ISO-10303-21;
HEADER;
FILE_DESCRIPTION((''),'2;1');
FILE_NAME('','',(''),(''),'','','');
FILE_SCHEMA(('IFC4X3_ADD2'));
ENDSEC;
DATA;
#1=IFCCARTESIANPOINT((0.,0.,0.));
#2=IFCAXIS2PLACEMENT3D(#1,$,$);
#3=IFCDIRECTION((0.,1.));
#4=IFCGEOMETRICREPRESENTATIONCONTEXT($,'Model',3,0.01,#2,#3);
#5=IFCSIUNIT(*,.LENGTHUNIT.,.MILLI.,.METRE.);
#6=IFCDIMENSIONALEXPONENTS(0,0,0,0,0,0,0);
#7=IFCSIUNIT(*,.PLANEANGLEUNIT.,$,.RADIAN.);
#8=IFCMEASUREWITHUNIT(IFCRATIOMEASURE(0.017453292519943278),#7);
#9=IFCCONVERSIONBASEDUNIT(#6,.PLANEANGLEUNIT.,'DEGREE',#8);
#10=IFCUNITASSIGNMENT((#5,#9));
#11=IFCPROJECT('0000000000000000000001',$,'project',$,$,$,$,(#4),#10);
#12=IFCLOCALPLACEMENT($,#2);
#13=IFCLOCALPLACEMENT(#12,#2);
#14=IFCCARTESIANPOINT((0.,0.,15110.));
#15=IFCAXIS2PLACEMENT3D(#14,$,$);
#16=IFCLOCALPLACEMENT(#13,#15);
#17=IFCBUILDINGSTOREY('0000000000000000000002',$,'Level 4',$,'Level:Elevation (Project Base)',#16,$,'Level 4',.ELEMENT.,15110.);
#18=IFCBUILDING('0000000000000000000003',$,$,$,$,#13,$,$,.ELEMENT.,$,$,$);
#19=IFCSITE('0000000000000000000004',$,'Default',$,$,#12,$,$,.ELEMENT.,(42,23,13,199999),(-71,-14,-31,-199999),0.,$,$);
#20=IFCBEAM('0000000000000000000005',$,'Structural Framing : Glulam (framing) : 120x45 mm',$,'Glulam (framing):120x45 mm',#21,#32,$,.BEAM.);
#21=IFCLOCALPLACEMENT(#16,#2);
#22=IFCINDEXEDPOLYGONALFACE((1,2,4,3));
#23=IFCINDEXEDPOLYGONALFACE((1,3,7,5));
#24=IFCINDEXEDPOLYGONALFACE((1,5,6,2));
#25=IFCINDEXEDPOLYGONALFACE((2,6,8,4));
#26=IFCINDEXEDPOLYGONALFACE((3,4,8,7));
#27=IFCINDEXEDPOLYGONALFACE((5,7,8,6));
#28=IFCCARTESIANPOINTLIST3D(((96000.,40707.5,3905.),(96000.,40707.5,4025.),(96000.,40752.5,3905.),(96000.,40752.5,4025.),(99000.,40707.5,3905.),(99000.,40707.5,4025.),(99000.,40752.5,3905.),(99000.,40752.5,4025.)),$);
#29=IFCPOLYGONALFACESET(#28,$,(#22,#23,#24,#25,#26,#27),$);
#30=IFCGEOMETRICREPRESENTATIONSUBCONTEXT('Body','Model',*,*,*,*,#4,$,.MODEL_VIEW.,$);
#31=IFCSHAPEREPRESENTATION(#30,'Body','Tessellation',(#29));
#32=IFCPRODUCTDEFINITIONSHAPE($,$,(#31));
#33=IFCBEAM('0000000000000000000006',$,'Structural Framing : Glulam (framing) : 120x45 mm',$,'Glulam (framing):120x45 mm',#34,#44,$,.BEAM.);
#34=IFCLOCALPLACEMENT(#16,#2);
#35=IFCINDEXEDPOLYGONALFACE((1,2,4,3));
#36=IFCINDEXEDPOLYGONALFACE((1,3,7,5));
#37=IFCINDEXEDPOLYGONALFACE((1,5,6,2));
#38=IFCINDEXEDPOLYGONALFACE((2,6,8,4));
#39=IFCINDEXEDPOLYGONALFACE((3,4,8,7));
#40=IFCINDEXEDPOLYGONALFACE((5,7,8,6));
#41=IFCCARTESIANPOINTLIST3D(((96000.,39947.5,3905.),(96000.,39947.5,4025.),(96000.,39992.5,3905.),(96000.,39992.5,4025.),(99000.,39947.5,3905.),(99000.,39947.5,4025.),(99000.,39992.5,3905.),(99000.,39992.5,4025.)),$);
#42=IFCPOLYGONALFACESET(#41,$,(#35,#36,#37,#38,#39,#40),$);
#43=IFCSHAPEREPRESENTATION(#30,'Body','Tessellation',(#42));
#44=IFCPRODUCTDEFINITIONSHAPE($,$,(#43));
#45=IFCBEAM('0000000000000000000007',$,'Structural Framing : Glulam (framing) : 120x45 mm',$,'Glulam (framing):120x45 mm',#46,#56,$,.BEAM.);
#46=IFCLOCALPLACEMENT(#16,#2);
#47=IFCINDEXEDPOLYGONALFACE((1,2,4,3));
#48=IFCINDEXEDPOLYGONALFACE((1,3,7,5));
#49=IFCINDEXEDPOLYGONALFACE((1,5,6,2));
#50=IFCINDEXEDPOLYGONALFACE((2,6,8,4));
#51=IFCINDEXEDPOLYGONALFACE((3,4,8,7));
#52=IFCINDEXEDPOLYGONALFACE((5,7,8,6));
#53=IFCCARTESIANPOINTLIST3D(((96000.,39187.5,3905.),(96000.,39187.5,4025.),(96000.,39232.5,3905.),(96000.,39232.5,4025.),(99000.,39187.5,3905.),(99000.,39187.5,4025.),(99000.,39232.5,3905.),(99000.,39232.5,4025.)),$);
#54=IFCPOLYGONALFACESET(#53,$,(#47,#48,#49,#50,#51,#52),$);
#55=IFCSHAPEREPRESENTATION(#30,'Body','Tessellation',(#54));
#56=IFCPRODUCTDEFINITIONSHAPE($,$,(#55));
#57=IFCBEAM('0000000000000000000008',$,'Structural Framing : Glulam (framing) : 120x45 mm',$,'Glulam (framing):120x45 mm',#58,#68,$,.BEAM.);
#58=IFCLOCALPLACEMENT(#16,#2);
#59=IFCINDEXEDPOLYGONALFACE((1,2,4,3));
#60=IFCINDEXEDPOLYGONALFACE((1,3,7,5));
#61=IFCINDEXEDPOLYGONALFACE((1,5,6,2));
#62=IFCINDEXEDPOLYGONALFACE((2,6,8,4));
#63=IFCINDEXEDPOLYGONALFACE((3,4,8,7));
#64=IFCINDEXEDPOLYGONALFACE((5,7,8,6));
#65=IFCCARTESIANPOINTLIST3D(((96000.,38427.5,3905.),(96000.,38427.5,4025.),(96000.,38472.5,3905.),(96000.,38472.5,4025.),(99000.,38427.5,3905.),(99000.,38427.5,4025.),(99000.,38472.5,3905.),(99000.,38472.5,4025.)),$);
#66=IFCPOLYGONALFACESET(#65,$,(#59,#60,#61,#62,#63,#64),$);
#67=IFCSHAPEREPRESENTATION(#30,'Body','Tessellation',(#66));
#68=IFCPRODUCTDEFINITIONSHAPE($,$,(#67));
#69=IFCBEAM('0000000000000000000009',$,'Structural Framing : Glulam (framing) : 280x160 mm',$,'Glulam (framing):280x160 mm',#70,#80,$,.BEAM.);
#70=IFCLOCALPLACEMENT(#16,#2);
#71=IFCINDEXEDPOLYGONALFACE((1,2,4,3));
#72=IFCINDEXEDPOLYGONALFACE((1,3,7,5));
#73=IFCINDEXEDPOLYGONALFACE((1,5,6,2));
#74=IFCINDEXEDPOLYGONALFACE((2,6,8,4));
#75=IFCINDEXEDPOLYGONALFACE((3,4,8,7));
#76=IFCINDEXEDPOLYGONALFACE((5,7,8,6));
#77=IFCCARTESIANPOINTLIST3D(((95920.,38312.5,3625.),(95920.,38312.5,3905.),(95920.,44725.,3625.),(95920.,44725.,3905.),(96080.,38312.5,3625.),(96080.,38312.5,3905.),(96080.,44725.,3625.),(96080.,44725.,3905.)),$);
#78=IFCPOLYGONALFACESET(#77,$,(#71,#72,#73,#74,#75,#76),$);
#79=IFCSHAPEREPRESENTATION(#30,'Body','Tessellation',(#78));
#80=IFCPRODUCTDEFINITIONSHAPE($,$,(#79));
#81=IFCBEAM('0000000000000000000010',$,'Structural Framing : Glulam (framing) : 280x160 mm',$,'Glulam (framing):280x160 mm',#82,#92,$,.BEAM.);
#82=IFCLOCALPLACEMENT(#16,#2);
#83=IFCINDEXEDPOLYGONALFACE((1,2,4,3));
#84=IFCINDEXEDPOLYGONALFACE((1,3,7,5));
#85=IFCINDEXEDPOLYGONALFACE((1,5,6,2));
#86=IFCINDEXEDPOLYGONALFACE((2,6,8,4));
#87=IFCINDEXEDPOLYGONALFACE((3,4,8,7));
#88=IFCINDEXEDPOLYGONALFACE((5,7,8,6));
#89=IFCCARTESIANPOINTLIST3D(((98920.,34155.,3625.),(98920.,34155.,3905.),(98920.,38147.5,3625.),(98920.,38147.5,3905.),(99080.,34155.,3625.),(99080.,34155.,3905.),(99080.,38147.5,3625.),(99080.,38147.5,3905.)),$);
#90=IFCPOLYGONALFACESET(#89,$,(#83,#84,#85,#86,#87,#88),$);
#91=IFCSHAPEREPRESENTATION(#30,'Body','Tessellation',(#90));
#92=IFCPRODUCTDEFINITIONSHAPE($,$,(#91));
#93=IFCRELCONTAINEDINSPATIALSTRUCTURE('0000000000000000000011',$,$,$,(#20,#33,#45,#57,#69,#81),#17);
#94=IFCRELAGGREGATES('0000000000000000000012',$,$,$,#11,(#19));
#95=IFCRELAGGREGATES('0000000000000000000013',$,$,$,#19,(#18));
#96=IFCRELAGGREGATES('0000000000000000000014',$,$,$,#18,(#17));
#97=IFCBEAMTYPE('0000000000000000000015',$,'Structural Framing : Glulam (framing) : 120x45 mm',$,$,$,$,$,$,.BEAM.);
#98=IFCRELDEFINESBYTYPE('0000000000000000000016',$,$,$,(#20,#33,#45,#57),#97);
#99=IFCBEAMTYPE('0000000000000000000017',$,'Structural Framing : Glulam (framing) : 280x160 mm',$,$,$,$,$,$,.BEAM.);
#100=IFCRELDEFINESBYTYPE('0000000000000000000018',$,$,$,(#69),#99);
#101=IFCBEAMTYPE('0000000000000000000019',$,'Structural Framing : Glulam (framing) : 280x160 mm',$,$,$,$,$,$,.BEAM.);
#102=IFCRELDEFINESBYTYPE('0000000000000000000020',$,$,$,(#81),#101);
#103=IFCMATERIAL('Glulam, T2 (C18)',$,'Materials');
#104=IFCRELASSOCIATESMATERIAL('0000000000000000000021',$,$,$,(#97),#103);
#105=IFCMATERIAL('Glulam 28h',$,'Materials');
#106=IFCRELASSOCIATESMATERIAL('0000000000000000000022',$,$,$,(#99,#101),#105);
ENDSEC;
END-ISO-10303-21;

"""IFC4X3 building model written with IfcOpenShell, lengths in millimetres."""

from ifc_helpers import new_model, entity, si_unit, converted_unit, direction, frame, origin, origin_2d_with_axis, place, context, subcontext, project, spatial, rectangle, extrude, source, transform, mapped, material, material_profile, profile_set, type_object, type_shapes, element, save


model = new_model("IFC4X3")

# Units and contexts
model_context = context("Model", 3, precision=0.01, world=origin(), true_north=direction((0.0, 1.0)))
body_context = subcontext(model_context, "Body", "Model", "MODEL_VIEW")
ifc_project = project(units=[si_unit("LENGTHUNIT", "METRE", prefix="MILLI"), converted_unit("PLANEANGLEUNIT", "DEGREE", entity("IfcRatioMeasure", 0.017453292519943278), si_unit("PLANEANGLEUNIT", "RADIAN"), dimensions=[0, 0, 0, 0, 0, 0, 0])], contexts=[model_context])

# Site, building, storey
site_placement = place(None, origin())
site = spatial("IfcSite", under=ifc_project, at=site_placement, Name="Default", CompositionType="ELEMENT", RefLatitude=(42, 23, 13, 199999), RefLongitude=(-71, -14, -31, -199999), RefElevation=0.0)
building_placement = place(site_placement, origin())
building = spatial("IfcBuilding", under=site, at=building_placement, CompositionType="ELEMENT")
storey_placement = place(building_placement, frame((0.0, 0.0, 15110.0)))
storey = spatial("IfcBuildingStorey", under=building, at=storey_placement, Name="Level 4", ObjectType="Level:Elevation (Project Base)", LongName="Level 4", CompositionType="ELEMENT", Elevation=15110.0)

# Beams
ifc_material_1 = material(Name="Glulam 28h", Category="Materials")
ifc_material_profile_1 = material_profile(ifc_material_1, rectangle(XDim=280.0, YDim=160.0, at=origin_2d_with_axis()), Name="280x160 mm")
ifc_profile_set_1 = profile_set([ifc_material_profile_1], Name="280x160 mm")
ifc_material_2 = material(Name="Glulam, T2 (C18)", Category="Materials")
ifc_material_profile_2 = material_profile(ifc_material_2, rectangle(XDim=120.0, YDim=45.0, at=origin_2d_with_axis()), Name="120x45 mm")
ifc_profile_set_2 = profile_set([ifc_material_profile_2], Name="120x45 mm")
beam_type_1 = type_object("IfcBeamType", Name="Structural Framing : Glulam (framing) : 120x45 mm", PredefinedType="BEAM", material=ifc_profile_set_2)
shared_shape_1 = source(origin(), body_context, "Body", "SweptSolid", [
    extrude(rectangle(XDim=120.0, YDim=45.0, at=origin_2d_with_axis()), frame((500.0, 0.0, 0.0), z_axis=(1.0, 0.0, 0.0), x_axis=(0.0, 0.0, -1.0)), (0.0, 0.0, 1.0), 3000.0),
])
type_shapes(beam_type_1, [shared_shape_1])
for number, where, name in (
    (1, (95500.0, 40730.0, 3965.0), "Structural Framing : Glulam (framing) : 120x45 mm"),
    (2, (95500.0, 39970.0, 3965.0), "Structural Framing : Glulam (framing) : 120x45 mm"),
    (3, (95500.0, 39210.0, 3965.0), "Structural Framing : Glulam (framing) : 120x45 mm"),
    (4, (95500.0, 38450.0, 3965.0), "Structural Framing : Glulam (framing) : 120x45 mm"),
):
    element("IfcBeam", number, at=place(storey_placement, frame(where)), inside=storey, type_object=beam_type_1, Name=name, ObjectType="Glulam (framing):120x45 mm", PredefinedType="BEAM", context=body_context, shape_type="MappedRepresentation", body=[
        mapped(shared_shape_1, transform((0.0, 0.0, 0.0), scale=1.0)),
    ])
beam_type_2 = type_object("IfcBeamType", Name="Structural Framing : Glulam (framing) : 280x160 mm", PredefinedType="BEAM", material=ifc_profile_set_1)
shared_shape_2 = source(origin(), body_context, "Body", "SweptSolid", [
    extrude(rectangle(XDim=280.0, YDim=160.0, at=origin_2d_with_axis()), frame((-2932.5, 0.0, 0.0), z_axis=(1.0, 0.0, 0.0), x_axis=(0.0, 0.0, -1.0)), (0.0, 0.0, 1.0), 6412.5),
])
type_shapes(beam_type_2, [shared_shape_2])
beam_1_placement = place(storey_placement, frame((96000.0, 41792.5, 3765.0), z_axis=(0.0, 0.0, 1.0), x_axis=(0.0, -1.0, 0.0)))
element("IfcBeam", 5, at=beam_1_placement, inside=storey, type_object=beam_type_2, Name="Structural Framing : Glulam (framing) : 280x160 mm", ObjectType="Glulam (framing):280x160 mm", PredefinedType="BEAM", context=body_context, shape_type="MappedRepresentation", body=[
    mapped(shared_shape_2, transform((0.0, 0.0, 0.0), scale=1.0)),
])
beam_type_3 = type_object("IfcBeamType", Name="Structural Framing : Glulam (framing) : 280x160 mm", PredefinedType="BEAM", material=ifc_profile_set_1)
shared_shape_3 = source(origin(), body_context, "Body", "SweptSolid", [
    extrude(rectangle(XDim=280.0, YDim=160.0, at=origin_2d_with_axis()), frame((2836.2, 0.0, 0.0), z_axis=(1.0, 0.0, 0.0), x_axis=(0.0, 0.0, -1.0)), (0.0, 0.0, 1.0), 3992.5),
])
type_shapes(beam_type_3, [shared_shape_3])
beam_2_placement = place(storey_placement, frame((99000.0, 40983.7, 3765.0), z_axis=(0.0, 0.0, 1.0), x_axis=(0.0, -1.0, 0.0)))
element("IfcBeam", 6, at=beam_2_placement, inside=storey, type_object=beam_type_3, Name="Structural Framing : Glulam (framing) : 280x160 mm", ObjectType="Glulam (framing):280x160 mm", PredefinedType="BEAM", context=body_context, shape_type="MappedRepresentation", body=[
    mapped(shared_shape_3, transform((0.0, 0.0, 0.0), scale=1.0)),
])

save(model, "model.ifc")
